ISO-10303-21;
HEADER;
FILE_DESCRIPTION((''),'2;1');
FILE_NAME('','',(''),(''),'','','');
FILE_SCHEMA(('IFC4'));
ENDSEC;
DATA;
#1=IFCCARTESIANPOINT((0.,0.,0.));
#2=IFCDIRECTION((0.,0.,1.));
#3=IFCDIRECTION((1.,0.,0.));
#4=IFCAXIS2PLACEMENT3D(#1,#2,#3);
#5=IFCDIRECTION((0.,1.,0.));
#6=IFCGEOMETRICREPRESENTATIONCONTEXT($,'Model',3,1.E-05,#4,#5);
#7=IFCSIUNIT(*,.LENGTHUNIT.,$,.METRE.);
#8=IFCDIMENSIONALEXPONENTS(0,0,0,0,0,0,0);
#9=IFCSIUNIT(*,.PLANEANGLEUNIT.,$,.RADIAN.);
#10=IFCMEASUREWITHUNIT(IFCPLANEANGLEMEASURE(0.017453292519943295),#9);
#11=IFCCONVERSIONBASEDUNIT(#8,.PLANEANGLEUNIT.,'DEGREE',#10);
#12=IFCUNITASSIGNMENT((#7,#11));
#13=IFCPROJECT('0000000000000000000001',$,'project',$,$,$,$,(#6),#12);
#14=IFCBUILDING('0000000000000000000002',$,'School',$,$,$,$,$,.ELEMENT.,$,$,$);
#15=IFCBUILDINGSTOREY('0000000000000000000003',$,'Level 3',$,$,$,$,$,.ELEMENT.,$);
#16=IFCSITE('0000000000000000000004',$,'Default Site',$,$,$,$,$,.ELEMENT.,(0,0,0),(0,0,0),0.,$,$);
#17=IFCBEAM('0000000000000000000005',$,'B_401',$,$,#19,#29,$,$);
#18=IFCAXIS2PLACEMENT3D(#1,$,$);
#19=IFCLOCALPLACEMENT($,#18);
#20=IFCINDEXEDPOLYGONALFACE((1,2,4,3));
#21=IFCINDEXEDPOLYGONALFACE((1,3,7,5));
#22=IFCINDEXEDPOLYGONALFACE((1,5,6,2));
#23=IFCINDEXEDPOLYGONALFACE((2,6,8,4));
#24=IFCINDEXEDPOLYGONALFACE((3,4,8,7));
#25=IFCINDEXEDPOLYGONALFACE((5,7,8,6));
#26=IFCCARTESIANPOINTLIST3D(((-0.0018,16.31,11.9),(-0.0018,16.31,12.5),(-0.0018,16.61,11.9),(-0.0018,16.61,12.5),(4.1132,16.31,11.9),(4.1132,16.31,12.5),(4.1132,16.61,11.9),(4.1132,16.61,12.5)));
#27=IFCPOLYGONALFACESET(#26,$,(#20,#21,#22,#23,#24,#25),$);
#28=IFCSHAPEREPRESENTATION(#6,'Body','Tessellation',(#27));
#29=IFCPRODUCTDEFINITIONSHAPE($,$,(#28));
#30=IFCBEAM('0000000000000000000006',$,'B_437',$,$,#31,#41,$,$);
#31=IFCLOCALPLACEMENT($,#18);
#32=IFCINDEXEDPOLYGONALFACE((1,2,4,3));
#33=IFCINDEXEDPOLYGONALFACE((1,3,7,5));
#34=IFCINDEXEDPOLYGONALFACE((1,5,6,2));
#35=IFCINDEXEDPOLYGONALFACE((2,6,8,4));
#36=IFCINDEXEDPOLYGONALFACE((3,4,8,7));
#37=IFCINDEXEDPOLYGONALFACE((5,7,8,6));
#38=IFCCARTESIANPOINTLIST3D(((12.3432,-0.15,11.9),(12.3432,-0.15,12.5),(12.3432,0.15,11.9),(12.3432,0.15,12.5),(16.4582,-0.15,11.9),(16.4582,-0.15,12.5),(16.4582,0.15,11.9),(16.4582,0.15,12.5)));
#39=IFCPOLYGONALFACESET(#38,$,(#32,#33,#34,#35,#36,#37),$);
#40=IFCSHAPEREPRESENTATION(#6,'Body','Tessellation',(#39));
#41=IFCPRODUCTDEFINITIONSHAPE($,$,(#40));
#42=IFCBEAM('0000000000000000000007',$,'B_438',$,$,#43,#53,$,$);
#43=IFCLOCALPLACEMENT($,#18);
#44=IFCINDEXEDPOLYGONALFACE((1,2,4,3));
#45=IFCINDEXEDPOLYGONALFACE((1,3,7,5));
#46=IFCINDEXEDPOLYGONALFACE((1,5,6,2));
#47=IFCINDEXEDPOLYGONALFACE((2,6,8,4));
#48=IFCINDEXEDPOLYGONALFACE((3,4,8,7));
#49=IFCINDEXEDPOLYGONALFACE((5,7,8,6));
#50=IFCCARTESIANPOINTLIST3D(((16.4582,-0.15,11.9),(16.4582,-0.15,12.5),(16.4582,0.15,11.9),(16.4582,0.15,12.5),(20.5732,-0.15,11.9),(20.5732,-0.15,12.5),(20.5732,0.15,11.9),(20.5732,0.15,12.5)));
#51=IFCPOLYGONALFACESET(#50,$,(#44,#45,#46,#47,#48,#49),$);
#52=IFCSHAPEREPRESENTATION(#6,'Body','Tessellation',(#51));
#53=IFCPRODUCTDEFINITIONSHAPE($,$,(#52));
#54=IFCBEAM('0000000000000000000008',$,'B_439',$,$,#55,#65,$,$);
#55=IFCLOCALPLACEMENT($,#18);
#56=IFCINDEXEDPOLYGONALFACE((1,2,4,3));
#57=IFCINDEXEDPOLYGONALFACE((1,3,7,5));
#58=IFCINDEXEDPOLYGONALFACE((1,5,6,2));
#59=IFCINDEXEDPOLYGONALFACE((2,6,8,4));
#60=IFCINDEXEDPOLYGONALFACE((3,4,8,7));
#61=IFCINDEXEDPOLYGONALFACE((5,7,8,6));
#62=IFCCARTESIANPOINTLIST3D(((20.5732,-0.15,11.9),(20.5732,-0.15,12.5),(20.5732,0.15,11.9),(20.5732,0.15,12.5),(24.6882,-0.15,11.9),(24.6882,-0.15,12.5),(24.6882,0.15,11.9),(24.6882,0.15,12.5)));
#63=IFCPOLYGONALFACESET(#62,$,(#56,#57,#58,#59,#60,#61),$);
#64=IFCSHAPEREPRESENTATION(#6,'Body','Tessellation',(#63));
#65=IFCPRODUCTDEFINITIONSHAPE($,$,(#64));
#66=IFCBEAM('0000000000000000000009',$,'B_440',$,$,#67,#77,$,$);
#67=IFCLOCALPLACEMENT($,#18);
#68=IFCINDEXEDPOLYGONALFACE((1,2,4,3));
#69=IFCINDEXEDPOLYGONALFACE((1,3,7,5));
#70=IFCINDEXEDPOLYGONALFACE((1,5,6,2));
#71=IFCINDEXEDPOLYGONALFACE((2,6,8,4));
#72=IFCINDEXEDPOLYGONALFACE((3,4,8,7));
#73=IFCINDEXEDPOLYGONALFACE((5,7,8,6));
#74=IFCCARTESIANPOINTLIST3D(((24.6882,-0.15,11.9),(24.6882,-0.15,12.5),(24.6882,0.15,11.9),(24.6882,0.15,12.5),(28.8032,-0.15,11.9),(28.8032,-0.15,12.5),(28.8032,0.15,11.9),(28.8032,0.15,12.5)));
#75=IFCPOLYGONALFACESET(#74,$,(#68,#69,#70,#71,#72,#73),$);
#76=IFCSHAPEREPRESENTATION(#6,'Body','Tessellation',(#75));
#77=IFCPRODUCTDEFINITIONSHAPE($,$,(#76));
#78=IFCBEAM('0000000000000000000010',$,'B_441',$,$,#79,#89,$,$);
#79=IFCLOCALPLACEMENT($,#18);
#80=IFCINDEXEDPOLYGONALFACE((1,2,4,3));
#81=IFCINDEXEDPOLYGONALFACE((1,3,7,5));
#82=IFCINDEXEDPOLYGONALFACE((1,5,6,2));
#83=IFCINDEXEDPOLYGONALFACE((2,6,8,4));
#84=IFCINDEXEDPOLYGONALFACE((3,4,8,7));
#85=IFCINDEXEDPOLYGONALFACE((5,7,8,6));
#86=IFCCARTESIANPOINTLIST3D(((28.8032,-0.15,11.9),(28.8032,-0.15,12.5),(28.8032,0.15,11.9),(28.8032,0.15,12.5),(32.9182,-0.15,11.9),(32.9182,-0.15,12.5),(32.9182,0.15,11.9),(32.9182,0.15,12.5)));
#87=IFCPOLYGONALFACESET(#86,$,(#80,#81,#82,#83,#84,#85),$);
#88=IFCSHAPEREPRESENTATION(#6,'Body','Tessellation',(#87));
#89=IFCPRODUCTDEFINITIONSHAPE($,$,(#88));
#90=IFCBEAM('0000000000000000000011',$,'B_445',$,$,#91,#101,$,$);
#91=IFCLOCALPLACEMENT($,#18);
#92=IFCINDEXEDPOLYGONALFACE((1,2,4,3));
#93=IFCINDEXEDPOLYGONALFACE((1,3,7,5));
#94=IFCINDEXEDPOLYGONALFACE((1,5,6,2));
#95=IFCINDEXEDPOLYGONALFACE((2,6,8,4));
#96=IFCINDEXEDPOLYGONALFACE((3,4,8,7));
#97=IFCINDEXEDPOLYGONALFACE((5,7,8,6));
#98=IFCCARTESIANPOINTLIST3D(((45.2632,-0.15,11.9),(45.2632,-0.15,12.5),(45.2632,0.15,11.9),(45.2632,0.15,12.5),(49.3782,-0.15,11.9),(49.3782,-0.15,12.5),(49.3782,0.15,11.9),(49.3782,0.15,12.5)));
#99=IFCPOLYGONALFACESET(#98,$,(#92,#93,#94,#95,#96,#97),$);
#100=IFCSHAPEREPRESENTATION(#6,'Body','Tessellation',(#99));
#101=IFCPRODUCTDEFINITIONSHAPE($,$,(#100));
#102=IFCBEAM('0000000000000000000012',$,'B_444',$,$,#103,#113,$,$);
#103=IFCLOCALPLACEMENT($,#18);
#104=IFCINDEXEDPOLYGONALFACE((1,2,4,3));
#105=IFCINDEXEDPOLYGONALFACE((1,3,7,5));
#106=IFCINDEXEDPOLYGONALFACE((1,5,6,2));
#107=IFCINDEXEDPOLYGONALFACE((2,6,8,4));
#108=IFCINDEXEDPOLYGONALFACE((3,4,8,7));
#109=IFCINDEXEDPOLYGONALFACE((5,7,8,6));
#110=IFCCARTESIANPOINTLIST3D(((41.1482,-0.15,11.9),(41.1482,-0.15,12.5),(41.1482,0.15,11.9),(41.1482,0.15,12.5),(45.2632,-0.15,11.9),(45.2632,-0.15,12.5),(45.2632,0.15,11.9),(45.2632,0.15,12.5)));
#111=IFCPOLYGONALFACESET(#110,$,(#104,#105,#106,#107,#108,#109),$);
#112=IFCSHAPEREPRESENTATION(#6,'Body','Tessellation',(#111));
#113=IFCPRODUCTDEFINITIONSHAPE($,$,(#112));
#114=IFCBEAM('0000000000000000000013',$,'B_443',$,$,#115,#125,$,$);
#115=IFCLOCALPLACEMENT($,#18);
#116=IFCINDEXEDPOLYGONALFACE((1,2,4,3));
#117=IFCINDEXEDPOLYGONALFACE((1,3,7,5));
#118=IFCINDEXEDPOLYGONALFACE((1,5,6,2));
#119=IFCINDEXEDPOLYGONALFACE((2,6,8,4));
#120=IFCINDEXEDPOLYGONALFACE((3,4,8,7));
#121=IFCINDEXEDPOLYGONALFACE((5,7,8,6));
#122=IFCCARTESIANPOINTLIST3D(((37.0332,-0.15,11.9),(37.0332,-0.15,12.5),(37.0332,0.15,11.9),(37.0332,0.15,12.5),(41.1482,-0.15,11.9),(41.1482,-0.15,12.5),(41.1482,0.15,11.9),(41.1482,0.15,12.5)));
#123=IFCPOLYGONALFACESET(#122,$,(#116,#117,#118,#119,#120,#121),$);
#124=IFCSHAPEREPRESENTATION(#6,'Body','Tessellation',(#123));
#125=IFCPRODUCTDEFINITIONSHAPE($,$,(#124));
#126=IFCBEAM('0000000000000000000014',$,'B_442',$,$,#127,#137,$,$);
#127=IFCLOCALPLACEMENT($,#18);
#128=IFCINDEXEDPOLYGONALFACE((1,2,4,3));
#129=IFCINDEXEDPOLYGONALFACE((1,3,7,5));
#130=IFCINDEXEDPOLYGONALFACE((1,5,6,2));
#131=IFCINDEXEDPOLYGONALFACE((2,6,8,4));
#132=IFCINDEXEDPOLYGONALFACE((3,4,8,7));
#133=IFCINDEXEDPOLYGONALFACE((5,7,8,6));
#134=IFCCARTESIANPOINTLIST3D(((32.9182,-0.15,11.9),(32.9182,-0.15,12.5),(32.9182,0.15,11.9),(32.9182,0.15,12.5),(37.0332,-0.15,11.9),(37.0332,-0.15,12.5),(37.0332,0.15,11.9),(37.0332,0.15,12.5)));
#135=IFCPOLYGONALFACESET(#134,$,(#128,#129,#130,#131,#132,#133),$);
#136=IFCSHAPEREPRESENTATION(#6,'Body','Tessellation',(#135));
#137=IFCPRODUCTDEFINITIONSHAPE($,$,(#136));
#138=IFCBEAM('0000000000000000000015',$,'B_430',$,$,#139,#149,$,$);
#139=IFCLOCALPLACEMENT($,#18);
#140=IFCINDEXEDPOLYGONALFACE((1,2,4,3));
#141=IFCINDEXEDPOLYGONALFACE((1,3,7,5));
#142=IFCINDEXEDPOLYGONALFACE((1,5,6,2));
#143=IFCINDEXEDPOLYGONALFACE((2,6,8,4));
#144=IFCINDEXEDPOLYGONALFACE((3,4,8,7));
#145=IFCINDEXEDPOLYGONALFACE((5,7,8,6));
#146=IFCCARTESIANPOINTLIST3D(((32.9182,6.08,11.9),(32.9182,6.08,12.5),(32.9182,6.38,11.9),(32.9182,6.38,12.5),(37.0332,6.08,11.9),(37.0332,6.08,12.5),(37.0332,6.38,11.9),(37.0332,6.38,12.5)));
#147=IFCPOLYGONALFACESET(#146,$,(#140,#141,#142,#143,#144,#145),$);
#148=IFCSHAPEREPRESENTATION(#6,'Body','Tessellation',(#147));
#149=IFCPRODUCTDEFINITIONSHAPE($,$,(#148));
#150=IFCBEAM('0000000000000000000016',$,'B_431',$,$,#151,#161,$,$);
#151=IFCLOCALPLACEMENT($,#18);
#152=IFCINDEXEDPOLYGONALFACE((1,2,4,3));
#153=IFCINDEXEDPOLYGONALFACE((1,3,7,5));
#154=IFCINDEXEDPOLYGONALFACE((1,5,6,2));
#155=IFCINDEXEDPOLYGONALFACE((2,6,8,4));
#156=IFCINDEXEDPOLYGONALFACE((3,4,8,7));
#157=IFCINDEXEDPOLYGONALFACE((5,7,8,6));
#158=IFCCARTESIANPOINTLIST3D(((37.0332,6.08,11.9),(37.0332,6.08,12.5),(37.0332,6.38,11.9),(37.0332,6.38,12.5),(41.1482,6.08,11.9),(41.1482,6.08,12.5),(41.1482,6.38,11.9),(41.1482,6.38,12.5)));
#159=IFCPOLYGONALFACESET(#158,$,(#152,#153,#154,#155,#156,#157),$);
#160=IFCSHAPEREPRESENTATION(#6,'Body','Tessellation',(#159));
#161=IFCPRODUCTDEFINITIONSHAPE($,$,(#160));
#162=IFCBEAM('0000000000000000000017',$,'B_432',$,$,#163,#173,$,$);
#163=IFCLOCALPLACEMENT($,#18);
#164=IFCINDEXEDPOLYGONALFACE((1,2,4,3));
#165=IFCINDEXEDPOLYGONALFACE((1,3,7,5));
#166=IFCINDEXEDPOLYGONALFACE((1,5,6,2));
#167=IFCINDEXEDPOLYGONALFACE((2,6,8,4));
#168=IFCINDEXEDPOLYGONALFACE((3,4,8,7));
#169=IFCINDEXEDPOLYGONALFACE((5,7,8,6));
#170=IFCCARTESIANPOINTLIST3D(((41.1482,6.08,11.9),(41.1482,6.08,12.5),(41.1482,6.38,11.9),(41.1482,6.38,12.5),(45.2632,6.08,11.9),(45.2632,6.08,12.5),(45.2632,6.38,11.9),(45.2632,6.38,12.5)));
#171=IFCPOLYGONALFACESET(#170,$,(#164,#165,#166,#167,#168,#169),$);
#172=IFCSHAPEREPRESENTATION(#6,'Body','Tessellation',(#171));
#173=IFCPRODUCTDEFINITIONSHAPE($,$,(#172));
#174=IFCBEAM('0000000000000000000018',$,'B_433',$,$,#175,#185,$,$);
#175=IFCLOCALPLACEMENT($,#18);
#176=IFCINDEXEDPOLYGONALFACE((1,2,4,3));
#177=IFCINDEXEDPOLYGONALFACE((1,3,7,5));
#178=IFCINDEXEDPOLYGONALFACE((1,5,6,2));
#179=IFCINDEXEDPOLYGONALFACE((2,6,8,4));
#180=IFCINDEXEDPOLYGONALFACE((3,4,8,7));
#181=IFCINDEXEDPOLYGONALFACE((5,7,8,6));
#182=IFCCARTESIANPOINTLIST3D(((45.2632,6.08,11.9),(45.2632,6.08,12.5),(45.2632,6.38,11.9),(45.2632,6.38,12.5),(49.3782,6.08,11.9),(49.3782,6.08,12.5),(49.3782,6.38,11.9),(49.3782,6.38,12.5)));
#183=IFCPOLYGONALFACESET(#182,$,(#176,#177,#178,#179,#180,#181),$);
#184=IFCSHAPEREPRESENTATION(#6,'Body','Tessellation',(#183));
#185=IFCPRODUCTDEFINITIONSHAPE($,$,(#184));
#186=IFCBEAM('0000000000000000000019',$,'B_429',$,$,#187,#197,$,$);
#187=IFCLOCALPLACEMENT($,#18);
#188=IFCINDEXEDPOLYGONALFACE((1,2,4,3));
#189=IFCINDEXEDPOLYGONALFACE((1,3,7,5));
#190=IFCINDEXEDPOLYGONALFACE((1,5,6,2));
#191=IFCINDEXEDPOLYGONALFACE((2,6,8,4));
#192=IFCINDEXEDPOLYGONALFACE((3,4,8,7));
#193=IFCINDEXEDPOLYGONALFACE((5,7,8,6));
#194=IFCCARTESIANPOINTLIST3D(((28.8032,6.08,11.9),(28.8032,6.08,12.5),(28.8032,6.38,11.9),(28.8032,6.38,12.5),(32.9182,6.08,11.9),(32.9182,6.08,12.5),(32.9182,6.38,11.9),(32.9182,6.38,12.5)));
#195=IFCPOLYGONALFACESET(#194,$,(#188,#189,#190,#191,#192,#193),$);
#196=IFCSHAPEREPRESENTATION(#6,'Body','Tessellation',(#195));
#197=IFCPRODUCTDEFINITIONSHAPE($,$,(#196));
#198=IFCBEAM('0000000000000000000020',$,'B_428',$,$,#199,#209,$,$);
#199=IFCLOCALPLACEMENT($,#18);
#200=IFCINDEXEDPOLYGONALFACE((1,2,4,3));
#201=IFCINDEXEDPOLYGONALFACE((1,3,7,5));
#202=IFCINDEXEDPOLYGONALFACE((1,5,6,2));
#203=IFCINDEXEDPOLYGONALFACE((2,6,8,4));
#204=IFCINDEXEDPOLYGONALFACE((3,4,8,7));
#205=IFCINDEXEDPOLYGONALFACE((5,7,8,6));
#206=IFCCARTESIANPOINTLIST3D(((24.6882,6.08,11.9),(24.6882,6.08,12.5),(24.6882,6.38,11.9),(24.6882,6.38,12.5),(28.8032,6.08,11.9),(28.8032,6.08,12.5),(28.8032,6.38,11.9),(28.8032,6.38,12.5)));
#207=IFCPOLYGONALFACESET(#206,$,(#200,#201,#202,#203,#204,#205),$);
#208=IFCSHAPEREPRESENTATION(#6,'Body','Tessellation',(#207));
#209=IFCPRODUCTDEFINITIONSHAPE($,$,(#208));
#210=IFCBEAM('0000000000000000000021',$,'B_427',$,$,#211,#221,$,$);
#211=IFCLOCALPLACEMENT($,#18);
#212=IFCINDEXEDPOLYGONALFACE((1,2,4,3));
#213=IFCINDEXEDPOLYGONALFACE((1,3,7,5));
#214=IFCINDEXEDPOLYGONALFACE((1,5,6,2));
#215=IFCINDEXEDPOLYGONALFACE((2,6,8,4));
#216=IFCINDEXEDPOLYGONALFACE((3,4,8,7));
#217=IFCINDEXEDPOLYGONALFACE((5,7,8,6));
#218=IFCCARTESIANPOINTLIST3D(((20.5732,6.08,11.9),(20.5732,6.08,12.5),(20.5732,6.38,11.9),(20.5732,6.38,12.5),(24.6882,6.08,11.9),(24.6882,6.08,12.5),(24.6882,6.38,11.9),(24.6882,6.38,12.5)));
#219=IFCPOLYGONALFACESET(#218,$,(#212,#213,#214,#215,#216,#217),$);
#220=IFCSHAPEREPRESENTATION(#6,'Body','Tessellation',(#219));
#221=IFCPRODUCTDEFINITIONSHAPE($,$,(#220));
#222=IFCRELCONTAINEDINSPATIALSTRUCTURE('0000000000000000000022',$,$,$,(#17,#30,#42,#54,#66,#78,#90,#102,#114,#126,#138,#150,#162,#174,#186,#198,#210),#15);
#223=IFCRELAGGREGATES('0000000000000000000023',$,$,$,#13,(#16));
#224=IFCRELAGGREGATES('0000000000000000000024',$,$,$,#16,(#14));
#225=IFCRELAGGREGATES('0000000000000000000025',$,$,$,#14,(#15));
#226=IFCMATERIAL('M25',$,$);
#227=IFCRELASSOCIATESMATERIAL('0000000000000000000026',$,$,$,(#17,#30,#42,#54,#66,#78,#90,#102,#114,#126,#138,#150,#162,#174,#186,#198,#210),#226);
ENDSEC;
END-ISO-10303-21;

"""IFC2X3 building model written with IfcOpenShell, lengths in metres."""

from ifc_helpers import new_model, entity, si_unit, converted_unit, direction, frame, frame_2d, origin_with_axes, place, context, project, spatial, rectangle, extrude, material, element, save


model = new_model("IFC2X3")

# Units and contexts
model_context = context("Model", 3, precision=1e-05, world=origin_with_axes(), true_north=direction((0.0, 1.0, 0.0)))
ifc_project = project(units=[si_unit("LENGTHUNIT", "METRE"), converted_unit("PLANEANGLEUNIT", "DEGREE", entity("IfcPlaneAngleMeasure", 0.017453292519943295), si_unit("PLANEANGLEUNIT", "RADIAN"), dimensions=[0, 0, 0, 0, 0, 0, 0])], contexts=[model_context])

# Site, building, storey
site = spatial("IfcSite", under=ifc_project, Name="Default Site", CompositionType="ELEMENT", RefLatitude=(0, 0, 0), RefLongitude=(0, 0, 0), RefElevation=0.0)
building = spatial("IfcBuilding", under=site, Name="School", CompositionType="ELEMENT")
storey = spatial("IfcBuildingStorey", under=building, Name="Level 3", CompositionType="ELEMENT")

# Beams
ifc_material = material(Name="M25")
placement = place(None, origin_with_axes())
element("IfcBeam", 1, at=placement, inside=storey, material=ifc_material, Name="B_401", context=model_context, shape_type="SweptSolid", body=[
    extrude(rectangle(XDim=0.3, YDim=0.6, at=frame_2d((0.0, 0.0), x_axis=(0.0, 1.0, 0.0))), frame((-0.0018, 16.46, 12.2), z_axis=(1.0, 0.0, 0.0), x_axis=(0.0, 0.0, -1.0)), (0.0, 0.0, 1.0), 4.115),
])
element("IfcBeam", 2, at=placement, inside=storey, material=ifc_material, Name="B_437", context=model_context, shape_type="SweptSolid", body=[
    extrude(rectangle(XDim=0.3, YDim=0.6, at=frame_2d((0.0, 0.0), x_axis=(0.0, 1.0, 0.0))), frame((12.3432, 0.0, 12.2), z_axis=(1.0, 0.0, 0.0), x_axis=(0.0, 0.0, -1.0)), (0.0, 0.0, 1.0), 4.115),
])
element("IfcBeam", 3, at=placement, inside=storey, material=ifc_material, Name="B_438", context=model_context, shape_type="SweptSolid", body=[
    extrude(rectangle(XDim=0.3, YDim=0.6, at=frame_2d((0.0, 0.0), x_axis=(0.0, 1.0, 0.0))), frame((16.4582, 0.0, 12.2), z_axis=(1.0, 0.0, 0.0), x_axis=(0.0, 0.0, -1.0)), (0.0, 0.0, 1.0), 4.115),
])
element("IfcBeam", 4, at=placement, inside=storey, material=ifc_material, Name="B_439", context=model_context, shape_type="SweptSolid", body=[
    extrude(rectangle(XDim=0.3, YDim=0.6, at=frame_2d((0.0, 0.0), x_axis=(0.0, 1.0, 0.0))), frame((20.5732, 0.0, 12.2), z_axis=(1.0, 0.0, 0.0), x_axis=(0.0, 0.0, -1.0)), (0.0, 0.0, 1.0), 4.115),
])
element("IfcBeam", 5, at=placement, inside=storey, material=ifc_material, Name="B_440", context=model_context, shape_type="SweptSolid", body=[
    extrude(rectangle(XDim=0.3, YDim=0.6, at=frame_2d((0.0, 0.0), x_axis=(0.0, 1.0, 0.0))), frame((24.6882, 0.0, 12.2), z_axis=(1.0, 0.0, 0.0), x_axis=(0.0, 0.0, -1.0)), (0.0, 0.0, 1.0), 4.115),
])
element("IfcBeam", 6, at=placement, inside=storey, material=ifc_material, Name="B_441", context=model_context, shape_type="SweptSolid", body=[
    extrude(rectangle(XDim=0.3, YDim=0.6, at=frame_2d((0.0, 0.0), x_axis=(0.0, 1.0, 0.0))), frame((28.8032, 0.0, 12.2), z_axis=(1.0, 0.0, 0.0), x_axis=(0.0, 0.0, -1.0)), (0.0, 0.0, 1.0), 4.115),
])
element("IfcBeam", 7, at=placement, inside=storey, material=ifc_material, Name="B_445", context=model_context, shape_type="SweptSolid", body=[
    extrude(rectangle(XDim=0.3, YDim=0.6, at=frame_2d((0.0, 0.0), x_axis=(0.0, 1.0, 0.0))), frame((45.2632, 0.0, 12.2), z_axis=(1.0, 0.0, 0.0), x_axis=(0.0, 0.0, -1.0)), (0.0, 0.0, 1.0), 4.115),
])
element("IfcBeam", 8, at=placement, inside=storey, material=ifc_material, Name="B_444", context=model_context, shape_type="SweptSolid", body=[
    extrude(rectangle(XDim=0.3, YDim=0.6, at=frame_2d((0.0, 0.0), x_axis=(0.0, 1.0, 0.0))), frame((41.1482, 0.0, 12.2), z_axis=(1.0, 0.0, 0.0), x_axis=(0.0, 0.0, -1.0)), (0.0, 0.0, 1.0), 4.115),
])
element("IfcBeam", 9, at=placement, inside=storey, material=ifc_material, Name="B_443", context=model_context, shape_type="SweptSolid", body=[
    extrude(rectangle(XDim=0.3, YDim=0.6, at=frame_2d((0.0, 0.0), x_axis=(0.0, 1.0, 0.0))), frame((37.0332, 0.0, 12.2), z_axis=(1.0, 0.0, 0.0), x_axis=(0.0, 0.0, -1.0)), (0.0, 0.0, 1.0), 4.115),
])
element("IfcBeam", 10, at=placement, inside=storey, material=ifc_material, Name="B_442", context=model_context, shape_type="SweptSolid", body=[
    extrude(rectangle(XDim=0.3, YDim=0.6, at=frame_2d((0.0, 0.0), x_axis=(0.0, 1.0, 0.0))), frame((32.9182, 0.0, 12.2), z_axis=(1.0, 0.0, 0.0), x_axis=(0.0, 0.0, -1.0)), (0.0, 0.0, 1.0), 4.115),
])
element("IfcBeam", 11, at=placement, inside=storey, material=ifc_material, Name="B_430", context=model_context, shape_type="SweptSolid", body=[
    extrude(rectangle(XDim=0.3, YDim=0.6, at=frame_2d((0.0, 0.0), x_axis=(0.0, 1.0, 0.0))), frame((32.9182, 6.23, 12.2), z_axis=(1.0, 0.0, 0.0), x_axis=(0.0, 0.0, -1.0)), (0.0, 0.0, 1.0), 4.115),
])
element("IfcBeam", 12, at=placement, inside=storey, material=ifc_material, Name="B_431", context=model_context, shape_type="SweptSolid", body=[
    extrude(rectangle(XDim=0.3, YDim=0.6, at=frame_2d((0.0, 0.0), x_axis=(0.0, 1.0, 0.0))), frame((37.0332, 6.23, 12.2), z_axis=(1.0, 0.0, 0.0), x_axis=(0.0, 0.0, -1.0)), (0.0, 0.0, 1.0), 4.115),
])
element("IfcBeam", 13, at=placement, inside=storey, material=ifc_material, Name="B_432", context=model_context, shape_type="SweptSolid", body=[
    extrude(rectangle(XDim=0.3, YDim=0.6, at=frame_2d((0.0, 0.0), x_axis=(0.0, 1.0, 0.0))), frame((41.1482, 6.23, 12.2), z_axis=(1.0, 0.0, 0.0), x_axis=(0.0, 0.0, -1.0)), (0.0, 0.0, 1.0), 4.115),
])
element("IfcBeam", 14, at=placement, inside=storey, material=ifc_material, Name="B_433", context=model_context, shape_type="SweptSolid", body=[
    extrude(rectangle(XDim=0.3, YDim=0.6, at=frame_2d((0.0, 0.0), x_axis=(0.0, 1.0, 0.0))), frame((45.2632, 6.23, 12.2), z_axis=(1.0, 0.0, 0.0), x_axis=(0.0, 0.0, -1.0)), (0.0, 0.0, 1.0), 4.115),
])
element("IfcBeam", 15, at=placement, inside=storey, material=ifc_material, Name="B_429", context=model_context, shape_type="SweptSolid", body=[
    extrude(rectangle(XDim=0.3, YDim=0.6, at=frame_2d((0.0, 0.0), x_axis=(0.0, 1.0, 0.0))), frame((28.8032, 6.23, 12.2), z_axis=(1.0, 0.0, 0.0), x_axis=(0.0, 0.0, -1.0)), (0.0, 0.0, 1.0), 4.115),
])
element("IfcBeam", 16, at=placement, inside=storey, material=ifc_material, Name="B_428", context=model_context, shape_type="SweptSolid", body=[
    extrude(rectangle(XDim=0.3, YDim=0.6, at=frame_2d((0.0, 0.0), x_axis=(0.0, 1.0, 0.0))), frame((24.6882, 6.23, 12.2), z_axis=(1.0, 0.0, 0.0), x_axis=(0.0, 0.0, -1.0)), (0.0, 0.0, 1.0), 4.115),
])
element("IfcBeam", 17, at=placement, inside=storey, material=ifc_material, Name="B_427", context=model_context, shape_type="SweptSolid", body=[
    extrude(rectangle(XDim=0.3, YDim=0.6, at=frame_2d((0.0, 0.0), x_axis=(0.0, 1.0, 0.0))), frame((20.5732, 6.23, 12.2), z_axis=(1.0, 0.0, 0.0), x_axis=(0.0, 0.0, -1.0)), (0.0, 0.0, 1.0), 4.115),
])

save(model, "model.ifc")
